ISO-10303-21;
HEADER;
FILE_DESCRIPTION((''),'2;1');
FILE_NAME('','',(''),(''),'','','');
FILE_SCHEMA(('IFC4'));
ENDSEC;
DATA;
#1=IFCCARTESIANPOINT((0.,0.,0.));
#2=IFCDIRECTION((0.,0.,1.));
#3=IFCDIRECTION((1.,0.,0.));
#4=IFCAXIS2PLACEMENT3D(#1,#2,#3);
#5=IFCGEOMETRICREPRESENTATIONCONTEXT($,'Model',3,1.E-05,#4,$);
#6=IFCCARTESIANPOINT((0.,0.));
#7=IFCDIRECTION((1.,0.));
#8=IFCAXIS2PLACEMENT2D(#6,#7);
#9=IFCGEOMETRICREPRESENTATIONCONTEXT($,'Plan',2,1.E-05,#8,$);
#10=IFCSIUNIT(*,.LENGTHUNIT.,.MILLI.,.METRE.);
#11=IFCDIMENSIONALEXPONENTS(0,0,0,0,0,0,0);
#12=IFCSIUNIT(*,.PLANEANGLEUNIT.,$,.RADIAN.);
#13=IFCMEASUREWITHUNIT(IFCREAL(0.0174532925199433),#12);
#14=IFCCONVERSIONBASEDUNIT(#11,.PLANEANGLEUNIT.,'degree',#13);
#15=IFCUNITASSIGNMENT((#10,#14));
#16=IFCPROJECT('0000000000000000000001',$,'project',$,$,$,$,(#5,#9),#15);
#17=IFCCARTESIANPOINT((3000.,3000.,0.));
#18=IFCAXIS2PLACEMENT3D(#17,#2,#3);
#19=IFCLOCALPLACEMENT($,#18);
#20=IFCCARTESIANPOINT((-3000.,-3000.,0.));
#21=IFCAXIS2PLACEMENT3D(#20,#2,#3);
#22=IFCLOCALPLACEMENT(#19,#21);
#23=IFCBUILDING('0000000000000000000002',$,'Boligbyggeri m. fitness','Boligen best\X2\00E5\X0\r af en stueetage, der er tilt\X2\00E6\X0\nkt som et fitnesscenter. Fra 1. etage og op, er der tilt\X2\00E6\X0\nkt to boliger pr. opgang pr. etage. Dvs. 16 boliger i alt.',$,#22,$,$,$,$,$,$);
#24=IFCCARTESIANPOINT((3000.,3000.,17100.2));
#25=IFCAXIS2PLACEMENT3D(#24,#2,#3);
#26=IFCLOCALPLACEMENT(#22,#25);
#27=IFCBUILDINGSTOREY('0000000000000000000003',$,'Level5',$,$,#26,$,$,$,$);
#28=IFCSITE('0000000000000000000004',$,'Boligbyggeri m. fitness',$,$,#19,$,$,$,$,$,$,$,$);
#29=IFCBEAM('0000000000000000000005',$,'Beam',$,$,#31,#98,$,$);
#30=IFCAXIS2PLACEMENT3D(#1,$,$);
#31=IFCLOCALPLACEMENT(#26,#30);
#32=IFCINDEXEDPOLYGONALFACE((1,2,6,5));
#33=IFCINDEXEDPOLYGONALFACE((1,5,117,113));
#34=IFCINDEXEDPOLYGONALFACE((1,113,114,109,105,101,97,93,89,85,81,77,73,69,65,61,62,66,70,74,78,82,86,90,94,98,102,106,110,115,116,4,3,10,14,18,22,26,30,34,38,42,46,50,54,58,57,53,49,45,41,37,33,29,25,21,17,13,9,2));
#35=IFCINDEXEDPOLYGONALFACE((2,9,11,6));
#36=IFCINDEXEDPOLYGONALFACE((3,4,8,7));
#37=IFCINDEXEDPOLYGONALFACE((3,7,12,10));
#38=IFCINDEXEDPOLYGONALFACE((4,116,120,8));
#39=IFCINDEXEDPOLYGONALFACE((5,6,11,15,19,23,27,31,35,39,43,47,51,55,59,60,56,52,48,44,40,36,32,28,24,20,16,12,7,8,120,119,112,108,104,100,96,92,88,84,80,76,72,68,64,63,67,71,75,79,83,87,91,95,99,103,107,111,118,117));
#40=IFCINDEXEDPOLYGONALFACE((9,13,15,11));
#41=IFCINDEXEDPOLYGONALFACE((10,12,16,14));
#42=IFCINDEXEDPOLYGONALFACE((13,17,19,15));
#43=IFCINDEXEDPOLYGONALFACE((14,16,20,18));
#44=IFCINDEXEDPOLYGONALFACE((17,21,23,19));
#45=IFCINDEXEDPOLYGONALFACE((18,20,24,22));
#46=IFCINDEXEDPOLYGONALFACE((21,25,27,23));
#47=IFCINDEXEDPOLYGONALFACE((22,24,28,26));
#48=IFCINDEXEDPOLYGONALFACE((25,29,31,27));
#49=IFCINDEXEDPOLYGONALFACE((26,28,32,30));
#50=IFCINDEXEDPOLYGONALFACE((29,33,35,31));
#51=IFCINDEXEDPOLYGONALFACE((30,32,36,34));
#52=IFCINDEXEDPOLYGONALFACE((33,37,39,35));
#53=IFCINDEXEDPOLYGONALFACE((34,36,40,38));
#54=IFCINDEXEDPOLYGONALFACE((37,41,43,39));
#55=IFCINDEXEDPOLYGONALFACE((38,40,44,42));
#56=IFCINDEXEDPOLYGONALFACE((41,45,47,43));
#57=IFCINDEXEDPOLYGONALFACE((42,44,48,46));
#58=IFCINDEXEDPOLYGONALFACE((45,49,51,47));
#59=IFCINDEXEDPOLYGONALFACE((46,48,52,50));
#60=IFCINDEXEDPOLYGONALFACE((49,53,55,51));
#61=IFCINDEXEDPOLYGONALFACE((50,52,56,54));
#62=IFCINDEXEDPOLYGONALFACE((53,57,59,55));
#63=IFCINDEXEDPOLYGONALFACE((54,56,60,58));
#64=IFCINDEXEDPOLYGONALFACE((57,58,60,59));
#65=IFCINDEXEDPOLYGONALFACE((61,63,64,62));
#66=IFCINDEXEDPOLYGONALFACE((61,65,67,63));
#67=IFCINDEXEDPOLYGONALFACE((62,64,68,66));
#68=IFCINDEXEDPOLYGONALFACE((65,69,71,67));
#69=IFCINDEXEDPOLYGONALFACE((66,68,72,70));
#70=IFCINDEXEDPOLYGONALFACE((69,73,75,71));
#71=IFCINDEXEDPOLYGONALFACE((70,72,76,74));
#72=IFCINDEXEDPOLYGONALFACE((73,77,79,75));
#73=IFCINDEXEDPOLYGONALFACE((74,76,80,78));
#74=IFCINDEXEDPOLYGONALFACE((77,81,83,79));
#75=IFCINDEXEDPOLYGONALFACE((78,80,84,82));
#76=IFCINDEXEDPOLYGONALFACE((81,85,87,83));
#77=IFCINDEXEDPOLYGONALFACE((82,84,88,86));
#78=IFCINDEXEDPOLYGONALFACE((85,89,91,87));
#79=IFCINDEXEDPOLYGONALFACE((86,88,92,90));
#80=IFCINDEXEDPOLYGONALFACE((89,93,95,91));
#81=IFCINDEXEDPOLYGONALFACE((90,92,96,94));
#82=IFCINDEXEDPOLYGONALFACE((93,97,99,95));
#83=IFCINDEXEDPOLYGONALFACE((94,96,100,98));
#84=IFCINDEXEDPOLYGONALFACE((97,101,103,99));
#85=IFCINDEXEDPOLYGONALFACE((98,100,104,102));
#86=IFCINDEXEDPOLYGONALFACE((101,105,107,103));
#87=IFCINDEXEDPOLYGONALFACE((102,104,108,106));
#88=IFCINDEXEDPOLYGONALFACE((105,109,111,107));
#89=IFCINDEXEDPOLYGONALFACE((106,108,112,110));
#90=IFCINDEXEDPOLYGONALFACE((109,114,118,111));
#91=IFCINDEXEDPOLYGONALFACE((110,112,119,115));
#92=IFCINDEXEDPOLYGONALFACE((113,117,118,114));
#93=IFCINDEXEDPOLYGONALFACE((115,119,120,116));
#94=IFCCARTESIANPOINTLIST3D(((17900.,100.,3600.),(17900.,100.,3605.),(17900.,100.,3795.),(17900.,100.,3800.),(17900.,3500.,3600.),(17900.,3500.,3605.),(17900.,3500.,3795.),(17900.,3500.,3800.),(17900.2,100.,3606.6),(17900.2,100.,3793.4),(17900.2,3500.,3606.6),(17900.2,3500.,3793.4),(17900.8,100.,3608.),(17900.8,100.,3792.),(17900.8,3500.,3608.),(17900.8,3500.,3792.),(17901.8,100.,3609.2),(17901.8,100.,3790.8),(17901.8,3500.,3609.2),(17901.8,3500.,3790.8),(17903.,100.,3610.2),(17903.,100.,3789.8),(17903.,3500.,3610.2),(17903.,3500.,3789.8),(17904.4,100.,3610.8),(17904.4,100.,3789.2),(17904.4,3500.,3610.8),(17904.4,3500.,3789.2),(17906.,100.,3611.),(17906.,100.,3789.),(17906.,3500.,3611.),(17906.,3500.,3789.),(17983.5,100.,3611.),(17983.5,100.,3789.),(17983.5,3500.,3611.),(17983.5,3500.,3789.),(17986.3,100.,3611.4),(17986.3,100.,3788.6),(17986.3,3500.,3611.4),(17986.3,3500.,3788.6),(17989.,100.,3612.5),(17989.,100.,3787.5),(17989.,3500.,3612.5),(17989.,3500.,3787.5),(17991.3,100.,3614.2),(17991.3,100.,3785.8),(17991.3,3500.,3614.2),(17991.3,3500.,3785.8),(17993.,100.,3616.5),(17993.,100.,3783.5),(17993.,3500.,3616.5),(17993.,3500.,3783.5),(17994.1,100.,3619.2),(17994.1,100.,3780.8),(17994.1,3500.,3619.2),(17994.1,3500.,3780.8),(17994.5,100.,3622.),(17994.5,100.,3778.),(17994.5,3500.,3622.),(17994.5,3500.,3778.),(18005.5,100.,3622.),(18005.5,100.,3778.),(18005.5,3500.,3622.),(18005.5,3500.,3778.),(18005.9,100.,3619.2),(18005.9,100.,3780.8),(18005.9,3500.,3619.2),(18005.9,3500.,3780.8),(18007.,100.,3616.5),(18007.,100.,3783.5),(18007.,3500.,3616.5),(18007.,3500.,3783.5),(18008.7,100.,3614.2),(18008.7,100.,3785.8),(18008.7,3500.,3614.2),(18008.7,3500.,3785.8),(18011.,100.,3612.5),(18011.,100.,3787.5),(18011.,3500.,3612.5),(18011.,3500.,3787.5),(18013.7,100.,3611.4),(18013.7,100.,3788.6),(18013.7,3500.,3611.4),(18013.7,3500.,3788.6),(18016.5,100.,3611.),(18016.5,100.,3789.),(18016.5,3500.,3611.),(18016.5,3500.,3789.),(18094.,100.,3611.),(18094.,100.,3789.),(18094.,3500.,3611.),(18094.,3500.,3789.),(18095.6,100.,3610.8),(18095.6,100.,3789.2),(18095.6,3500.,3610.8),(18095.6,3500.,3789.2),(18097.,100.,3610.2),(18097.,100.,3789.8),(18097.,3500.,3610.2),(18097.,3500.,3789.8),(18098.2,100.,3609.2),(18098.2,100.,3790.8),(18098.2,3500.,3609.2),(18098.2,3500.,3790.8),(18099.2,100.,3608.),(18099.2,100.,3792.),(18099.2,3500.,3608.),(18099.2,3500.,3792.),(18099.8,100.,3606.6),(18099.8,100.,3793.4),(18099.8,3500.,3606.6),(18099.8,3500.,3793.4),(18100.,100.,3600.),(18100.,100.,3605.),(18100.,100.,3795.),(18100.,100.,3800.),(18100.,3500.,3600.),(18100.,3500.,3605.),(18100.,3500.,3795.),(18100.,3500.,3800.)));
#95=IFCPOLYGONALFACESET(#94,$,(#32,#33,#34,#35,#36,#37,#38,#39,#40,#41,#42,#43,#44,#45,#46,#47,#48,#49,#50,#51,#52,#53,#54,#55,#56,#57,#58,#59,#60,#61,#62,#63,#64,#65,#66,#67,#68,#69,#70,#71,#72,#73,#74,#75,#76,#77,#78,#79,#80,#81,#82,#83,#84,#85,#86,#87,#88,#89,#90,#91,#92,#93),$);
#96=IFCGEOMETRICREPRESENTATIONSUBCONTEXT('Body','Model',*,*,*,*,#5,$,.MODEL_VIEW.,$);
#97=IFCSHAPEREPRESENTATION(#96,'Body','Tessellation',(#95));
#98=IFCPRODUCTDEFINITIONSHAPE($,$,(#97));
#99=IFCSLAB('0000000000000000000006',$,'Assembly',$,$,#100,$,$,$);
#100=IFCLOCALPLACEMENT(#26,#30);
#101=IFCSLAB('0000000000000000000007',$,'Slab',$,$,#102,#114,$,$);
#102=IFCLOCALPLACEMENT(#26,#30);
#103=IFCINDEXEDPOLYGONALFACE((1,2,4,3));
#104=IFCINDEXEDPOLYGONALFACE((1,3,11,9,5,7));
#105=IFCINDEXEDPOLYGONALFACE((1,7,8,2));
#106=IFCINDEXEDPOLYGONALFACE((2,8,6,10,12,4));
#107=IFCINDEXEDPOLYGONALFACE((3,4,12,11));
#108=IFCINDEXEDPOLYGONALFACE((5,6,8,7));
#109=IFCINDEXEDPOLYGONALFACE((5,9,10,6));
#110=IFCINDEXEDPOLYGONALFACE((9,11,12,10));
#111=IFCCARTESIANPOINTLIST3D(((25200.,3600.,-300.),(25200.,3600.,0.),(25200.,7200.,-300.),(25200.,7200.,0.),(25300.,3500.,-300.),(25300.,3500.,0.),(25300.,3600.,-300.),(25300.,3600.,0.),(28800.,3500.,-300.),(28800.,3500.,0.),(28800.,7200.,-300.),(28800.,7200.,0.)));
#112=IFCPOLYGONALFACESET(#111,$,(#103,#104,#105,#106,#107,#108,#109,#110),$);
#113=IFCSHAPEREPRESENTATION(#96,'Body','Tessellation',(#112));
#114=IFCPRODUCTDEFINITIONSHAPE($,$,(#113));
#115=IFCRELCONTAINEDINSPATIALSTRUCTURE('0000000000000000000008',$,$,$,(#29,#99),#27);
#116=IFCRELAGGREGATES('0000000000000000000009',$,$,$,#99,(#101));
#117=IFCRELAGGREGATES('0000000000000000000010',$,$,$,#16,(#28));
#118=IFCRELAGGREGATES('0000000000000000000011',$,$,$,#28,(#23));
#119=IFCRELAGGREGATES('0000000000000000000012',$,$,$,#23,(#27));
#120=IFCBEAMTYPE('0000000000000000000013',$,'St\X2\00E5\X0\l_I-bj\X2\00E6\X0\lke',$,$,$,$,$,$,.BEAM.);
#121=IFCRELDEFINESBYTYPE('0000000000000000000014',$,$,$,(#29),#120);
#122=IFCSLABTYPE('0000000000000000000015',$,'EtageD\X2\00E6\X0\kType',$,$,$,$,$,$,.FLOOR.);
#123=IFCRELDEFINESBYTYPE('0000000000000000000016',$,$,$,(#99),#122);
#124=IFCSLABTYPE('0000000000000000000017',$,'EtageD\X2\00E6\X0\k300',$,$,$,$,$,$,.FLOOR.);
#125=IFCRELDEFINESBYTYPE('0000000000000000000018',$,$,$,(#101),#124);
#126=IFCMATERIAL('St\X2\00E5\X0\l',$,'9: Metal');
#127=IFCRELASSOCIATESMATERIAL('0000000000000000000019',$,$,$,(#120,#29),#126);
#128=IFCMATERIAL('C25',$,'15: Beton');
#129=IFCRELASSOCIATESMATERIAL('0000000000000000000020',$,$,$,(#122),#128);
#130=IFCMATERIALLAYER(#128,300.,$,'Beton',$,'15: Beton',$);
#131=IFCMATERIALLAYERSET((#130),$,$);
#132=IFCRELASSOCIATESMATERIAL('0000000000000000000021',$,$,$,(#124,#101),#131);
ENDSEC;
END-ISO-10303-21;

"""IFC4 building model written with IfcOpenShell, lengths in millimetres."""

from ifc_helpers import new_model, entity, si_unit, converted_unit, frame, origin_with_axes, origin_2d_with_axis, place, context, subcontext, project, spatial, line, indexed_curve, i_section, outline, extrude, material, layer, layer_set, layer_usage, material_profile, profile_set, profile_usage, type_object, element, aggregate, save


model = new_model("IFC4")

# Units and contexts
model_context = context("Model", 3, precision=1e-05, world=origin_with_axes())
plan_context = context("Plan", 2, precision=1e-05, world=origin_2d_with_axis())
body_context = subcontext(model_context, "Body", "Model", "MODEL_VIEW")
ifc_project = project(units=[si_unit("LENGTHUNIT", "METRE", prefix="MILLI"), converted_unit("PLANEANGLEUNIT", "degree", entity("IfcReal", 0.0174532925199433), si_unit("PLANEANGLEUNIT", "RADIAN"), dimensions=[0, 0, 0, 0, 0, 0, 0])], contexts=[model_context, plan_context])

# Site, building, storey
site_placement = place(None, frame((3000.0, 3000.0, 0.0), z_axis=(0.0, 0.0, 1.0), x_axis=(1.0, 0.0, 0.0)))
site = spatial("IfcSite", under=ifc_project, at=site_placement, Name="Boligbyggeri m. fitness")
building_placement = place(site_placement, frame((-3000.0, -3000.0, 0.0), z_axis=(0.0, 0.0, 1.0), x_axis=(1.0, 0.0, 0.0)))
building = spatial("IfcBuilding", under=site, at=building_placement, Name="Boligbyggeri m. fitness", Description="Boligen består af en stueetage, der er tiltænkt som et fitnesscenter. Fra 1. etage og op, er der tiltænkt to boliger pr. opgang pr. etage. Dvs. 16 boliger i alt.")
storey_placement = place(building_placement, frame((3000.0, 3000.0, 17100.2), z_axis=(0.0, 0.0, 1.0), x_axis=(1.0, 0.0, 0.0)))
storey = spatial("IfcBuildingStorey", under=building, at=storey_placement, Name="Level5")

# Shared definitions
ifc_material_1 = material(Name="C25", Category="15: Beton")

# Beam
ifc_material_2 = material(Name="Stål", Category="9: Metal")
ifc_material_profile_1 = material_profile(ifc_material_2, i_section(OverallWidth=200.0, OverallDepth=200.0, WebThickness=11.0, FlangeThickness=11.0, FilletRadius=11.0, FlangeEdgeRadius=6.0), Name="Stål", Category="9: Metal")
ifc_profile_set_1 = profile_set([ifc_material_profile_1], Name="NY_I-Profil")
beam_type = type_object("IfcBeamType", Name="Stål_I-bjælke", PredefinedType="BEAM", material=ifc_profile_set_1)
ifc_profile_usage_1 = profile_usage(ifc_profile_set_1, cardinal=9)
beam_1_placement = place(storey_placement, frame((18100.0, 100.0, 3800.0), z_axis=(0.0, 1.0, 0.0), x_axis=(-1.0, 0.0, 0.0)))
element("IfcBeam", 1, at=beam_1_placement, inside=storey, type_object=beam_type, material=ifc_profile_usage_1, Name="Beam", context=body_context, shape_type="SweptSolid", body=[
    extrude(i_section(OverallWidth=200.0, OverallDepth=200.0, WebThickness=11.0, FlangeThickness=11.0, FilletRadius=11.0, FlangeEdgeRadius=6.0), frame((100.0, -100.0, 0.0), z_axis=(0.0, 0.0, 1.0), x_axis=(1.0, 0.0, 0.0)), (0.0, 0.0, 1.0), 3400.0),
])

# Slabs
slab_type_1 = type_object("IfcSlabType", Name="EtageDækType", PredefinedType="FLOOR", material=ifc_material_1)
ifc_layer = layer(ifc_material_1, 300.0, Name="Beton", Category="15: Beton")
ifc_layer_set = layer_set([ifc_layer])
slab_type_2 = type_object("IfcSlabType", Name="EtageDæk300", PredefinedType="FLOOR", material=ifc_layer_set)
slab_1_placement = place(storey_placement, frame((25300.0, 3700.0, -17099.9), z_axis=(0.0, 0.0, 1.0), x_axis=(1.0, 0.0, 0.0)))
slab_1 = element("IfcSlab", 2, at=slab_1_placement, inside=storey, type_object=slab_type_1, Name="Assembly")
ifc_layer_usage_1 = layer_usage(ifc_layer_set, "AXIS3", "POSITIVE", 0.0)
slab_2_placement = place(slab_1_placement, frame((-100.0, -100.0, 16799.9), z_axis=(0.0, 0.0, 1.0), x_axis=(1.0, 0.0, 0.0)))
slab_2 = element("IfcSlab", 3, at=slab_2_placement, type_object=slab_type_2, material=ifc_layer_usage_1, Name="Slab", context=body_context, shape_type="SweptSolid", body=[
    extrude(outline(indexed_curve([(0.0, 0.0), (0.0, 3600.0), (3600.0, 3600.0), (3600.0, -100.0), (100.0, -100.0), (100.0, 0.0)], segments=[line(6, 5), line(5, 4), line(4, 3), line(3, 2), line(2, 1), line(1, 6)], self_intersect=False)), None, (0.0, 0.0, 1.0), 300.0),
])
aggregate(slab_1, [slab_2])

save(model, "model.ifc")
